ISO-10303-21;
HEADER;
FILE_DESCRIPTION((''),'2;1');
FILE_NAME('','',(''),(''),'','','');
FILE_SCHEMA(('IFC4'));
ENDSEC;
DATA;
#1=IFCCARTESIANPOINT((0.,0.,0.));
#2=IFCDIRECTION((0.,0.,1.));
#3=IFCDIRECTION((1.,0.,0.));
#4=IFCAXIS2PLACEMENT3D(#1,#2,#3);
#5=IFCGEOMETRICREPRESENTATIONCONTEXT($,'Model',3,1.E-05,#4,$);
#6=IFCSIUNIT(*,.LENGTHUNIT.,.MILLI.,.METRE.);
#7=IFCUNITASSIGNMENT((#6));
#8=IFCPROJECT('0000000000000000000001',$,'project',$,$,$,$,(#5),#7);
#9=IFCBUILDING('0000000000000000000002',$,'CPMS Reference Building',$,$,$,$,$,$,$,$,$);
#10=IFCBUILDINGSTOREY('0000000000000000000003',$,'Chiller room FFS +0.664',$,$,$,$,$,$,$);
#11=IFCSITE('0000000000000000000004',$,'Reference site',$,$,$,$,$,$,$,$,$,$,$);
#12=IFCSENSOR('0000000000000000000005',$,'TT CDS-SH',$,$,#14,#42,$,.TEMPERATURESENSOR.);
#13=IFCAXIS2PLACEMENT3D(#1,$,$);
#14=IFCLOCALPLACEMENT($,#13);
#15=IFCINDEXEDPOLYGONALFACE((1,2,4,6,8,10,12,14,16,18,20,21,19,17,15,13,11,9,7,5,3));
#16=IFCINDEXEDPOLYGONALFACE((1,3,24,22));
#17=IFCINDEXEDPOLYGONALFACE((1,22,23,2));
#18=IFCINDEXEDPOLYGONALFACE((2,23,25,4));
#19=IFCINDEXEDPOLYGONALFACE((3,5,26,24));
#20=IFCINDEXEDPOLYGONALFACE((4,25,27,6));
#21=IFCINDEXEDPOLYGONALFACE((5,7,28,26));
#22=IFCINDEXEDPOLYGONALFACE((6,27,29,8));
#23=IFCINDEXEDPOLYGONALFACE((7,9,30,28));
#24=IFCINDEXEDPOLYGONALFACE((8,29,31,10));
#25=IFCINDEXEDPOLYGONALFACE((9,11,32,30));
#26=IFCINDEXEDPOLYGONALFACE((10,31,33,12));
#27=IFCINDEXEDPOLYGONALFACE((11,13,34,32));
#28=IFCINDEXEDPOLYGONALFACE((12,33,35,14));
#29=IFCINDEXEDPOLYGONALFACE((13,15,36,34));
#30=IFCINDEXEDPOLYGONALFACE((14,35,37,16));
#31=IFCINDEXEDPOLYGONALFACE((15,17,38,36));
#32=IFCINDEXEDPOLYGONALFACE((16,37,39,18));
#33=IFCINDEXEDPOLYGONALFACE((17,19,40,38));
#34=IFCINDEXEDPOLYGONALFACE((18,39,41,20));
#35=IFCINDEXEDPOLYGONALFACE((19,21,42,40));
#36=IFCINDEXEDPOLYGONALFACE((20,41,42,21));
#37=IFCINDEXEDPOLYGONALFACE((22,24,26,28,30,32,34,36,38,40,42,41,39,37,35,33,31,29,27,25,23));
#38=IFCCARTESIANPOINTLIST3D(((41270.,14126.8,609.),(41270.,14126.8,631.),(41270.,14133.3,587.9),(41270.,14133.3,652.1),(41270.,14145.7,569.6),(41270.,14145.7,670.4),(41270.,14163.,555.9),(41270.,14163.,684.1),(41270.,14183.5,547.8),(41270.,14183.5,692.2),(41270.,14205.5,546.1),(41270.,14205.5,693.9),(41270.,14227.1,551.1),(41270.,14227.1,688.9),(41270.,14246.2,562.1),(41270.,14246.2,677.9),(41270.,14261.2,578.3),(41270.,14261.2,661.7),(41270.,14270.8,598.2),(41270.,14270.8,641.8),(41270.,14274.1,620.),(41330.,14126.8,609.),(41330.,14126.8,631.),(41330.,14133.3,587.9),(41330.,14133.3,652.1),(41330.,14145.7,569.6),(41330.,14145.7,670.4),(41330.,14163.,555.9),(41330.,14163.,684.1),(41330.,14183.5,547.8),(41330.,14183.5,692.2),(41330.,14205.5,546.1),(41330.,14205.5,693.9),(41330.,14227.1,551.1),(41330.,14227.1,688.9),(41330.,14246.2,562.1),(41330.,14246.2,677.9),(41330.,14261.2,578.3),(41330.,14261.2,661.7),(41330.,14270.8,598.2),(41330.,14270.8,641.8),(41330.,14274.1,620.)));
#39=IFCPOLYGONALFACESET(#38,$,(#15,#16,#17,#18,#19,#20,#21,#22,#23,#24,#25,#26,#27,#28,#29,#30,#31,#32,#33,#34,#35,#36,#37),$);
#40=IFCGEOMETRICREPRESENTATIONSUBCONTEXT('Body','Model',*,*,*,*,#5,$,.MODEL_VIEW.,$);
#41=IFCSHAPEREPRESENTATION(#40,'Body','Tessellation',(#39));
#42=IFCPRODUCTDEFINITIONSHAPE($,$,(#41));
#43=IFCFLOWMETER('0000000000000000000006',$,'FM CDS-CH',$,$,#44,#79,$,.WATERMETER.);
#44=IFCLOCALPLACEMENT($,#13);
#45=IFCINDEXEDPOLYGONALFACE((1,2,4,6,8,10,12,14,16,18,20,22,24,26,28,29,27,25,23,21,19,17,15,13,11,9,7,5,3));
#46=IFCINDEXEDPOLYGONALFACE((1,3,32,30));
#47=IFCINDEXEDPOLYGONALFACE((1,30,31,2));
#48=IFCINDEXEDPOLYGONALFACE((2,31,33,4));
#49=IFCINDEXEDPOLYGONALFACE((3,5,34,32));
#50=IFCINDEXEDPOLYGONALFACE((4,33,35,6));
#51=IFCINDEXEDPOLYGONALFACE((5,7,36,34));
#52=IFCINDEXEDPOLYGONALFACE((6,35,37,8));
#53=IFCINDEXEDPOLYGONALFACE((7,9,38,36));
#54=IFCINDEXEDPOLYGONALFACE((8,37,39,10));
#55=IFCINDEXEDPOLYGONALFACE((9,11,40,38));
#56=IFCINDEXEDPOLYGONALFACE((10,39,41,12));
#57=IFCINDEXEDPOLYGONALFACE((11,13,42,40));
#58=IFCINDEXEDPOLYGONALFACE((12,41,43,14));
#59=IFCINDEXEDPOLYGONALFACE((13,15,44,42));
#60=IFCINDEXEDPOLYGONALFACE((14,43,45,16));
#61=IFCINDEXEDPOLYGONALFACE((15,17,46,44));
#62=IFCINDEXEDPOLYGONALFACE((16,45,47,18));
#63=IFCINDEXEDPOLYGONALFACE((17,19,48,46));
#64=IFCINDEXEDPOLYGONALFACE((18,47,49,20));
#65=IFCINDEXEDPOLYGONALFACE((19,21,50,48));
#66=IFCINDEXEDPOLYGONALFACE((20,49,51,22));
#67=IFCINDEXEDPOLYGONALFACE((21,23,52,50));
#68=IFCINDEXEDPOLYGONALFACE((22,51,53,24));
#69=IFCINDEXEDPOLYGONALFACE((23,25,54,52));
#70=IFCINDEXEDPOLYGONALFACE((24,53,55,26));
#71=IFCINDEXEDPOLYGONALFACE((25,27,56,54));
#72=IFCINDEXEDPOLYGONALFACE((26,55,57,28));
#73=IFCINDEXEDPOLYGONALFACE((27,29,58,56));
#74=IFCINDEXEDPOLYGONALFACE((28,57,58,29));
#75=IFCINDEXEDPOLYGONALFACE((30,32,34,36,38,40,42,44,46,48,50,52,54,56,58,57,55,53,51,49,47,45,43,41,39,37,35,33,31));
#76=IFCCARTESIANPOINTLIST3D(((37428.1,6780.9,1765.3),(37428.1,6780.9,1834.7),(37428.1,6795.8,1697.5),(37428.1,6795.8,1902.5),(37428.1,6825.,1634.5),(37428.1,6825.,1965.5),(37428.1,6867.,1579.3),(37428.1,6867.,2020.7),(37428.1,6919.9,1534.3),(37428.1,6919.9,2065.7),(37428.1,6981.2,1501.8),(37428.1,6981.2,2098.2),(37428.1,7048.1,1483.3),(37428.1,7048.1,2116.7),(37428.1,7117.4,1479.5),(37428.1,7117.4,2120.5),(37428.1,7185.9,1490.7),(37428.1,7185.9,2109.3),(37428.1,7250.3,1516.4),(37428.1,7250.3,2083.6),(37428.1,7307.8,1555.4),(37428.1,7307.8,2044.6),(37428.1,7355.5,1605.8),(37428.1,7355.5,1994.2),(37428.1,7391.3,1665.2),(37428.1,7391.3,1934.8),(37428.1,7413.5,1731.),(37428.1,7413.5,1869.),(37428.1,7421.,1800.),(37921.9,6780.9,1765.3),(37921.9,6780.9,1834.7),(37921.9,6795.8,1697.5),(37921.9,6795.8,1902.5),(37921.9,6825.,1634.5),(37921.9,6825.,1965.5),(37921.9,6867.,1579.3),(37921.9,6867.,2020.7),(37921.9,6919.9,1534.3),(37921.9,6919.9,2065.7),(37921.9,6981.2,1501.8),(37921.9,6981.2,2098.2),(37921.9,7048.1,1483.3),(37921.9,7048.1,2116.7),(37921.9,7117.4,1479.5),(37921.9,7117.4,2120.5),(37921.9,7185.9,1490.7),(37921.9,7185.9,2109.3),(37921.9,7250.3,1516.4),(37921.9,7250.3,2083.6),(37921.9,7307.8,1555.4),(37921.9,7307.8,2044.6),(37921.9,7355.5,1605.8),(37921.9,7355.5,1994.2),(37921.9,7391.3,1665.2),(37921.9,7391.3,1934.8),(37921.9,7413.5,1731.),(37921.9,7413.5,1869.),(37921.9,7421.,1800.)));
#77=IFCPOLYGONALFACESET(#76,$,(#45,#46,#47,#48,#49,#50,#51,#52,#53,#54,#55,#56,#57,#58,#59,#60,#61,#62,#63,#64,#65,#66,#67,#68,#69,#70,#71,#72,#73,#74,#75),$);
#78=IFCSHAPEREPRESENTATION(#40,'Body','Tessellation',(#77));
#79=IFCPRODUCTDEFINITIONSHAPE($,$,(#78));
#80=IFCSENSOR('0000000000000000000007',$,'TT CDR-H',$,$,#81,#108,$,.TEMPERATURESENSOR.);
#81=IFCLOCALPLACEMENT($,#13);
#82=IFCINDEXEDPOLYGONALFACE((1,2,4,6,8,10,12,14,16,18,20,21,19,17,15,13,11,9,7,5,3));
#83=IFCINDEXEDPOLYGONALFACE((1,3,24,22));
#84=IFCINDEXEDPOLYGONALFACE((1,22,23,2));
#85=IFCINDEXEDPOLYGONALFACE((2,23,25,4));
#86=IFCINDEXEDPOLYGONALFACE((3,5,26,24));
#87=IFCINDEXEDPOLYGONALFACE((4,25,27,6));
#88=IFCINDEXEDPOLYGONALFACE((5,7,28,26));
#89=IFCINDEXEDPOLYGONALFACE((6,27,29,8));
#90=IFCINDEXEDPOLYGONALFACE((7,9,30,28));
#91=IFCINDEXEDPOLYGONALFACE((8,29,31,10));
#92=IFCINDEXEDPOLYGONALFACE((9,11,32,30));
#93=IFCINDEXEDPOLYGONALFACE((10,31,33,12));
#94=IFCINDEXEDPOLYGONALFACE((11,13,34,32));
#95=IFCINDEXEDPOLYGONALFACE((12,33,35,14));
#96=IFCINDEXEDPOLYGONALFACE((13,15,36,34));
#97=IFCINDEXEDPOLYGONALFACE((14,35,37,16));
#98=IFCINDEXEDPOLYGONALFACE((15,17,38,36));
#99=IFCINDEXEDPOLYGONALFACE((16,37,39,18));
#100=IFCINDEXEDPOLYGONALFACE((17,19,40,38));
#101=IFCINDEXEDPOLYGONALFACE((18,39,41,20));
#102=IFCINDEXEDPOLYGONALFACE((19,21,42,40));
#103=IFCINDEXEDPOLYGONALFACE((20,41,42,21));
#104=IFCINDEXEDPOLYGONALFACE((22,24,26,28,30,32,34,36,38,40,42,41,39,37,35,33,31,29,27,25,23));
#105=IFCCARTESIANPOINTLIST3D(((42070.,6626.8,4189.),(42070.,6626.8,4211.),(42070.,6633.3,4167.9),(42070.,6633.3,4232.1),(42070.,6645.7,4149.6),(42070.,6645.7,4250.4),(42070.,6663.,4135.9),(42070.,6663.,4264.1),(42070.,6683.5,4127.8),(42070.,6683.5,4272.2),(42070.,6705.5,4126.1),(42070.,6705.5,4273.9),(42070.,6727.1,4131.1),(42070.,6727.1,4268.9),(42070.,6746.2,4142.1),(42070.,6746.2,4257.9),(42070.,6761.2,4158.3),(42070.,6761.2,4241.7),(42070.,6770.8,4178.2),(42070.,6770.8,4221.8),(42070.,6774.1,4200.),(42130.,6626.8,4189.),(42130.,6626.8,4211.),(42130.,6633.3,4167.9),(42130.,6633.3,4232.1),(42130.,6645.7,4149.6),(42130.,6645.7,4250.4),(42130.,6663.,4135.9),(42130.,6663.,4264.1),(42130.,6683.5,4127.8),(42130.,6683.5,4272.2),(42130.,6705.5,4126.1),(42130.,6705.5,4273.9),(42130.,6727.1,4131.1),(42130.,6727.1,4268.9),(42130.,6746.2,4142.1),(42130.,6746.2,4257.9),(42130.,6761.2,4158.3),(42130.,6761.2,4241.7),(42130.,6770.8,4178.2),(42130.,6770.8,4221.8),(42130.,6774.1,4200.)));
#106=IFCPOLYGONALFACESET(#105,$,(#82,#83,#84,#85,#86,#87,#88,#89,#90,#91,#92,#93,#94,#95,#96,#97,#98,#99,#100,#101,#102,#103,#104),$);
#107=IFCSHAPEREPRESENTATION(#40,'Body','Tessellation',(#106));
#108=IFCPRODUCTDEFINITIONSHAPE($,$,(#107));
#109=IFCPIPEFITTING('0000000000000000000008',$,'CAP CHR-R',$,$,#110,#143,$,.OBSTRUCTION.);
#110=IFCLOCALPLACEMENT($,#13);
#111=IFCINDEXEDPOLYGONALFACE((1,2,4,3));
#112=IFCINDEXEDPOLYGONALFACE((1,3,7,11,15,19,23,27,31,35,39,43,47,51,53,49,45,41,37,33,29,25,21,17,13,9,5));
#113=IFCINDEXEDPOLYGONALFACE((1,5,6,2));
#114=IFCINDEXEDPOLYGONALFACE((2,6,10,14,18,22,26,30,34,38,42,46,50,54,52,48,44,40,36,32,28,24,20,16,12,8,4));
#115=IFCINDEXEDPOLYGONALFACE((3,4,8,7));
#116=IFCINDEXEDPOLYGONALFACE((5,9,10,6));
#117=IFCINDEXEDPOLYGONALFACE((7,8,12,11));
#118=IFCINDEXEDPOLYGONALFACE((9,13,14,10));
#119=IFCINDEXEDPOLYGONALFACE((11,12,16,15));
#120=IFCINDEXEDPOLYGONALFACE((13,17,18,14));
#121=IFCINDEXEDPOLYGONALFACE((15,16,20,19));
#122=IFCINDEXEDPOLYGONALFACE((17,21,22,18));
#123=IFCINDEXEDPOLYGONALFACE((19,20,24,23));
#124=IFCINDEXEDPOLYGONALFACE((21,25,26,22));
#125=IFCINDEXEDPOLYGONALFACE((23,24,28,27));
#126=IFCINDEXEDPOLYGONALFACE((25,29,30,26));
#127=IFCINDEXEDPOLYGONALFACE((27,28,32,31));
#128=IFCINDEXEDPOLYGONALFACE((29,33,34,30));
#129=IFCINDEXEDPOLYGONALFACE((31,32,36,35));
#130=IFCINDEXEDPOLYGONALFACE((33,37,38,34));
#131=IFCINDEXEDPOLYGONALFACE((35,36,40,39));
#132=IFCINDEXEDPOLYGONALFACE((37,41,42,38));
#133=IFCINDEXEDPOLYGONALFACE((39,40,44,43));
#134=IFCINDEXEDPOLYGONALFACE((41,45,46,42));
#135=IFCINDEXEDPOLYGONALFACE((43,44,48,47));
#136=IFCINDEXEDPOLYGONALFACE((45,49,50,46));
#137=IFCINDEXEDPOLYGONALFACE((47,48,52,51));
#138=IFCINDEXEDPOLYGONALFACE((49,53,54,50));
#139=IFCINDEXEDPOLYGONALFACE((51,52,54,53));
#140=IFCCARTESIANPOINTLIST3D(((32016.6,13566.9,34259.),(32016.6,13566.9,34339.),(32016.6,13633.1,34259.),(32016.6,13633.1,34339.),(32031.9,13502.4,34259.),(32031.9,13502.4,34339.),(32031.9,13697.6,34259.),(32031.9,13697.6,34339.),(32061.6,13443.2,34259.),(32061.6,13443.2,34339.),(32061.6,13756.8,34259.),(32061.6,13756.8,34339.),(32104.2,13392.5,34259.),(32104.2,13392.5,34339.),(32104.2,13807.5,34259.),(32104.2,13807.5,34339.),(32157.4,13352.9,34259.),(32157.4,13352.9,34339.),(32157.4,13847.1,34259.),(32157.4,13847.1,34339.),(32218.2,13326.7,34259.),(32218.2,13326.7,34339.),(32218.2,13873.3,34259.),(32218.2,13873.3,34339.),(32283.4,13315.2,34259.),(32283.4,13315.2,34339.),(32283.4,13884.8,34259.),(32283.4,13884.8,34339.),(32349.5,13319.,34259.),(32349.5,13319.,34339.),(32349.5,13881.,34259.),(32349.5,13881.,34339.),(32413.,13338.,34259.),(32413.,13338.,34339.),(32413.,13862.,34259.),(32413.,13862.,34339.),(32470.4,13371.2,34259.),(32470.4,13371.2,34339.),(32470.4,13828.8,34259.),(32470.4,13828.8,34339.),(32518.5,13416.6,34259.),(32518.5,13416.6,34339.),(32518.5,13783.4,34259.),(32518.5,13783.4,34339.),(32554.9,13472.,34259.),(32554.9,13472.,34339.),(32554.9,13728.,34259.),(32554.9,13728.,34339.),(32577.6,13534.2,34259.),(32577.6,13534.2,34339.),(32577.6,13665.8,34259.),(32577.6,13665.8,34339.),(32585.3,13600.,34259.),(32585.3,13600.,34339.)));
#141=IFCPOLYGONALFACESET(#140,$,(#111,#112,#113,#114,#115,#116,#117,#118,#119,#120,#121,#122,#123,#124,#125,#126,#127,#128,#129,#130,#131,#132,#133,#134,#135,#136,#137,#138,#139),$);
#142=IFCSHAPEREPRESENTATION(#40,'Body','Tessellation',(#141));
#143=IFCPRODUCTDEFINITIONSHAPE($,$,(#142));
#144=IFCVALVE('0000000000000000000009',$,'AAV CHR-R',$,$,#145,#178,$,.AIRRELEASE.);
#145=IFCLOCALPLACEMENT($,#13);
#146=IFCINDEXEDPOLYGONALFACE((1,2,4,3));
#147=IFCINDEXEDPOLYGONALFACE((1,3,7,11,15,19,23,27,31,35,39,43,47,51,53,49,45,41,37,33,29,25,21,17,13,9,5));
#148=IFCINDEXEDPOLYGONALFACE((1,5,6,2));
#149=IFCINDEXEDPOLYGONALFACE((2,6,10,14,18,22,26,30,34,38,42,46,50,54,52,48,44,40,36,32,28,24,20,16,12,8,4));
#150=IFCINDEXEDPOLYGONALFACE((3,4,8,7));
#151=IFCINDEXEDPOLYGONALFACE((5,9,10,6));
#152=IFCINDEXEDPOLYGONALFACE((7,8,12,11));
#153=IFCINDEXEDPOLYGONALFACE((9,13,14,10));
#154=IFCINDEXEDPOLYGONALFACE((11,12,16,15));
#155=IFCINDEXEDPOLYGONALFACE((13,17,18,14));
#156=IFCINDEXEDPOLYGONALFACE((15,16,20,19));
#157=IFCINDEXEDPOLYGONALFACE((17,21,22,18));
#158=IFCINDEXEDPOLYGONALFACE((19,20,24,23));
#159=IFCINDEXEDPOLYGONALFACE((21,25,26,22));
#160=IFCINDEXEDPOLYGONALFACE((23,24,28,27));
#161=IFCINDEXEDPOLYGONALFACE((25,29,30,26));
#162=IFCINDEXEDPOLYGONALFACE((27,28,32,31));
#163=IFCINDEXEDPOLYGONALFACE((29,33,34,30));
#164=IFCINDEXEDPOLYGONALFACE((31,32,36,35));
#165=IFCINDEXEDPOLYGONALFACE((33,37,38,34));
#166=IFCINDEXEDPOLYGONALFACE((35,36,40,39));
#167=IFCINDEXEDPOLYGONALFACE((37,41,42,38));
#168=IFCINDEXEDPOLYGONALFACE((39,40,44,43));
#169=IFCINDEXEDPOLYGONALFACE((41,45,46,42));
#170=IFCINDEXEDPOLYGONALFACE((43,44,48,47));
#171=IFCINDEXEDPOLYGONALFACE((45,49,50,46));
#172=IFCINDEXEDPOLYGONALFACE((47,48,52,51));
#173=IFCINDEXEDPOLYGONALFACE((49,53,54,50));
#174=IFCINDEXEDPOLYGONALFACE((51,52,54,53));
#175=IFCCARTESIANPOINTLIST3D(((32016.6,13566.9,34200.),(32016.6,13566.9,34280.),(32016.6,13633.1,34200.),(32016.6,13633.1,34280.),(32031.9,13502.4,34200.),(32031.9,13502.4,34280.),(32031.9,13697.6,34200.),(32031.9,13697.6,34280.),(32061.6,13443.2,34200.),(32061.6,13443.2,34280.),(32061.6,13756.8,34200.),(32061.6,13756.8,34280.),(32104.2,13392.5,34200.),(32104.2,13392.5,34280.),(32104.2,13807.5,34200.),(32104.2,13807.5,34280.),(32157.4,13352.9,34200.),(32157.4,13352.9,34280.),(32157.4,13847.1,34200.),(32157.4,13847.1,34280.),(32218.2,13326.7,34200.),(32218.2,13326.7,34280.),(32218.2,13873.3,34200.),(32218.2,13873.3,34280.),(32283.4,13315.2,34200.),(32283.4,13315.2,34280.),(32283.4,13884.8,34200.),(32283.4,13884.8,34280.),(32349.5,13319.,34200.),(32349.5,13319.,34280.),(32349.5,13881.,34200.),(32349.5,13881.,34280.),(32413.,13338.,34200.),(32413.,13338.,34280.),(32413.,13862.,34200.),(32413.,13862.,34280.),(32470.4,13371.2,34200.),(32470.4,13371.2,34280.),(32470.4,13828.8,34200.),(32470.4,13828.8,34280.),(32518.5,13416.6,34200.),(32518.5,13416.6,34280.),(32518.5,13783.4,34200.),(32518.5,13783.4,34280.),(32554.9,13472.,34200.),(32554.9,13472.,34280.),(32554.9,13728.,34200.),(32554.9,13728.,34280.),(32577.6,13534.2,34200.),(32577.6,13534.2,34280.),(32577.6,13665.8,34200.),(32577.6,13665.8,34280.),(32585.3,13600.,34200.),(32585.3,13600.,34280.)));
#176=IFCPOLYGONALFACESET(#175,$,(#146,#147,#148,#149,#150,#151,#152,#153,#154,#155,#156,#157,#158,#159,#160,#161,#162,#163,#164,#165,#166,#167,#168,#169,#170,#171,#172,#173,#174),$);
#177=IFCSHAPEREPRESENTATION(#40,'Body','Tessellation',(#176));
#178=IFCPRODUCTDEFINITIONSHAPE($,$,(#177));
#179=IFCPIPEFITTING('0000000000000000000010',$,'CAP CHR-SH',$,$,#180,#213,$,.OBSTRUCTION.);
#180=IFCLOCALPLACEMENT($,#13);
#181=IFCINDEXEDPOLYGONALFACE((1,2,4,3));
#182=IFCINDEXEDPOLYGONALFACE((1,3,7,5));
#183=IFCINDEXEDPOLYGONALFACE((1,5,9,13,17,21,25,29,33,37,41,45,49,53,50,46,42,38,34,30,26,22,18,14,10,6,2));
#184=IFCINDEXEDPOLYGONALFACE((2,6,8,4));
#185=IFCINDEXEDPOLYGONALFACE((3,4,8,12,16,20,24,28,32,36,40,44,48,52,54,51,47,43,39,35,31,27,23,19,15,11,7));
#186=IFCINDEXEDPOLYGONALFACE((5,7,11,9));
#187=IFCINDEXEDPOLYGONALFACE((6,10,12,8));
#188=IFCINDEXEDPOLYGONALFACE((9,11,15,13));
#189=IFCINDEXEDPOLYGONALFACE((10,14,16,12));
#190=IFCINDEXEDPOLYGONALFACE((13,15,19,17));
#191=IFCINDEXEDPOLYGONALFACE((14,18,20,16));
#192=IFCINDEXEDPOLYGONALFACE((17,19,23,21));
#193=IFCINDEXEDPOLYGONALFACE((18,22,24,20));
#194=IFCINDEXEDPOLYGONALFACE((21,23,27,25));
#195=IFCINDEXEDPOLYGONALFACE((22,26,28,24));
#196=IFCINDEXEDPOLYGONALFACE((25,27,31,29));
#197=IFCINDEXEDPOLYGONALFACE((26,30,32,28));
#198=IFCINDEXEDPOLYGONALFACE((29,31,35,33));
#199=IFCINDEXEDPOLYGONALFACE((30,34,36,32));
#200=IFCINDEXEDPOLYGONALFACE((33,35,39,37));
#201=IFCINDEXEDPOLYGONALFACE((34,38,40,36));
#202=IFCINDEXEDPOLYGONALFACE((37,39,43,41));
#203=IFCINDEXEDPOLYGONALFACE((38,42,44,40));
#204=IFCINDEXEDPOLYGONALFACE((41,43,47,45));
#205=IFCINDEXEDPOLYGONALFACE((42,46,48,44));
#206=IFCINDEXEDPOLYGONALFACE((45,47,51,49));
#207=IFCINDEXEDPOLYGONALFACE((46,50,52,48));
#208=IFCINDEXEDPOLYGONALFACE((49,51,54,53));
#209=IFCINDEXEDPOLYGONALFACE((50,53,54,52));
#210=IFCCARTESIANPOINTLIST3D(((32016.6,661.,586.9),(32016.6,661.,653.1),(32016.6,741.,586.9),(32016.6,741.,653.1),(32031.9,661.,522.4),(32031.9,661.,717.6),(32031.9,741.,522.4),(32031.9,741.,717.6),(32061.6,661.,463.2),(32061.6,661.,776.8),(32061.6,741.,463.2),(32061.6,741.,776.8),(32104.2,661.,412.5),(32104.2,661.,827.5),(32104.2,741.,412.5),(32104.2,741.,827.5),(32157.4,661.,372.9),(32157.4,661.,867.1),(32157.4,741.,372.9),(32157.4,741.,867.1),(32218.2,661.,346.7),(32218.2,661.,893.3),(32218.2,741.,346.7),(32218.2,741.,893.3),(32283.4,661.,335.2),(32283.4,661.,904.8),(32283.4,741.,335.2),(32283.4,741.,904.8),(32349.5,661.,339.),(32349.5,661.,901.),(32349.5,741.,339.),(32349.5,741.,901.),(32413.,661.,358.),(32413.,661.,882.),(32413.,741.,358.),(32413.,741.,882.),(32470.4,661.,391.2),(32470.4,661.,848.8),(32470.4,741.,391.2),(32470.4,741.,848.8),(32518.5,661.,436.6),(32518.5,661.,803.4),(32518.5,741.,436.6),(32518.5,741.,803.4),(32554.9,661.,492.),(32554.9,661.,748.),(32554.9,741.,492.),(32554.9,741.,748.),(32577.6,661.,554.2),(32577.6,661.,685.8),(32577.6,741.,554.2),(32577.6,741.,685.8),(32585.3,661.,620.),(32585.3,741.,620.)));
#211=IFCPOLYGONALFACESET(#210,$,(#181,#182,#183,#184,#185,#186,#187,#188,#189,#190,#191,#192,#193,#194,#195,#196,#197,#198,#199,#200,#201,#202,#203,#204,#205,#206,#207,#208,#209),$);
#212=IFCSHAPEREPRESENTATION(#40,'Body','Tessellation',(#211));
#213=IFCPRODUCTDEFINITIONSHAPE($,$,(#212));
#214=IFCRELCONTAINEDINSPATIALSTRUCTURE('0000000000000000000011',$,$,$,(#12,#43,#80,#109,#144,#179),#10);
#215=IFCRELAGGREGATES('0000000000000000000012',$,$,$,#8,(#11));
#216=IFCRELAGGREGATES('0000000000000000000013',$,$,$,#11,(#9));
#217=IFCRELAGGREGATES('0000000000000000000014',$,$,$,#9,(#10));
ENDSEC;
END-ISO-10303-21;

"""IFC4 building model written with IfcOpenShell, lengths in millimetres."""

from ifc_helpers import new_model, si_unit, frame, origin_with_axes, origin_2d, place, context, subcontext, project, spatial, circle_curve, outline, extrude, element, save


model = new_model("IFC4")

# Units and contexts
model_context = context("Model", 3, precision=1e-05, world=origin_with_axes())
body_context = subcontext(model_context, "Body", "Model", "MODEL_VIEW")
ifc_project = project(units=[si_unit("LENGTHUNIT", "METRE", prefix="MILLI")], contexts=[model_context])

# Site, building, storey
site = spatial("IfcSite", under=ifc_project, Name="Reference site")
building = spatial("IfcBuilding", under=site, Name="CPMS Reference Building")
storey = spatial("IfcBuildingStorey", under=building, Name="Chiller room FFS +0.664")

# Sensor
sensor_1_placement = place(None, origin_with_axes())
element("IfcSensor", 1, at=sensor_1_placement, inside=storey, Name="TT CDS-SH", PredefinedType="TEMPERATURESENSOR", context=body_context, shape_type="SweptSolid", body=[
    extrude(outline(circle_curve(origin_2d(), 74.1)), frame((41330.0, 14200.0, 620.0), z_axis=(-1.0, 0.0, 0.0), x_axis=(0.0, 1.0, 0.0)), (0.0, 0.0, 1.0), 60.0),
])

# Flow meter
flow_meter_1_placement = place(None, origin_with_axes())
element("IfcFlowMeter", 2, at=flow_meter_1_placement, inside=storey, Name="FM CDS-CH", PredefinedType="WATERMETER", context=body_context, shape_type="SweptSolid", body=[
    extrude(outline(circle_curve(origin_2d(), 321.0)), frame((37921.9, 7100.0, 1800.0), z_axis=(-1.0, 0.0, 0.0), x_axis=(0.0, 1.0, 0.0)), (0.0, 0.0, 1.0), 493.8),
])

# Sensor
sensor_2_placement = place(None, origin_with_axes())
element("IfcSensor", 3, at=sensor_2_placement, inside=storey, Name="TT CDR-H", PredefinedType="TEMPERATURESENSOR", context=body_context, shape_type="SweptSolid", body=[
    extrude(outline(circle_curve(origin_2d(), 74.1)), frame((42070.0, 6700.0, 4200.0), z_axis=(1.0, 0.0, 0.0), x_axis=(0.0, 1.0, 0.0)), (0.0, 0.0, 1.0), 60.0),
])

# Pipe fitting
pipe_fitting_1_placement = place(None, origin_with_axes())
element("IfcPipeFitting", 4, at=pipe_fitting_1_placement, inside=storey, Name="CAP CHR-R", PredefinedType="OBSTRUCTION", context=body_context, shape_type="SweptSolid", body=[
    extrude(outline(circle_curve(origin_2d(), 285.3)), frame((32300.0, 13600.0, 34339.0), z_axis=(0.0, 0.0, -1.0), x_axis=(1.0, 0.0, 0.0)), (0.0, 0.0, 1.0), 80.0),
])

# Valve
valve_1_placement = place(None, origin_with_axes())
element("IfcValve", 5, at=valve_1_placement, inside=storey, Name="AAV CHR-R", PredefinedType="AIRRELEASE", context=body_context, shape_type="SweptSolid", body=[
    extrude(outline(circle_curve(origin_2d(), 285.3)), frame((32300.0, 13600.0, 34280.0), z_axis=(0.0, 0.0, -1.0), x_axis=(1.0, 0.0, 0.0)), (0.0, 0.0, 1.0), 80.0),
])

# Pipe fitting
pipe_fitting_2_placement = place(None, origin_with_axes())
element("IfcPipeFitting", 6, at=pipe_fitting_2_placement, inside=storey, Name="CAP CHR-SH", PredefinedType="OBSTRUCTION", context=body_context, shape_type="SweptSolid", body=[
    extrude(outline(circle_curve(origin_2d(), 285.3)), frame((32300.0, 741.0, 620.0), z_axis=(0.0, -1.0, 0.0), x_axis=(1.0, 0.0, 0.0)), (0.0, 0.0, 1.0), 80.0),
])

save(model, "model.ifc")
